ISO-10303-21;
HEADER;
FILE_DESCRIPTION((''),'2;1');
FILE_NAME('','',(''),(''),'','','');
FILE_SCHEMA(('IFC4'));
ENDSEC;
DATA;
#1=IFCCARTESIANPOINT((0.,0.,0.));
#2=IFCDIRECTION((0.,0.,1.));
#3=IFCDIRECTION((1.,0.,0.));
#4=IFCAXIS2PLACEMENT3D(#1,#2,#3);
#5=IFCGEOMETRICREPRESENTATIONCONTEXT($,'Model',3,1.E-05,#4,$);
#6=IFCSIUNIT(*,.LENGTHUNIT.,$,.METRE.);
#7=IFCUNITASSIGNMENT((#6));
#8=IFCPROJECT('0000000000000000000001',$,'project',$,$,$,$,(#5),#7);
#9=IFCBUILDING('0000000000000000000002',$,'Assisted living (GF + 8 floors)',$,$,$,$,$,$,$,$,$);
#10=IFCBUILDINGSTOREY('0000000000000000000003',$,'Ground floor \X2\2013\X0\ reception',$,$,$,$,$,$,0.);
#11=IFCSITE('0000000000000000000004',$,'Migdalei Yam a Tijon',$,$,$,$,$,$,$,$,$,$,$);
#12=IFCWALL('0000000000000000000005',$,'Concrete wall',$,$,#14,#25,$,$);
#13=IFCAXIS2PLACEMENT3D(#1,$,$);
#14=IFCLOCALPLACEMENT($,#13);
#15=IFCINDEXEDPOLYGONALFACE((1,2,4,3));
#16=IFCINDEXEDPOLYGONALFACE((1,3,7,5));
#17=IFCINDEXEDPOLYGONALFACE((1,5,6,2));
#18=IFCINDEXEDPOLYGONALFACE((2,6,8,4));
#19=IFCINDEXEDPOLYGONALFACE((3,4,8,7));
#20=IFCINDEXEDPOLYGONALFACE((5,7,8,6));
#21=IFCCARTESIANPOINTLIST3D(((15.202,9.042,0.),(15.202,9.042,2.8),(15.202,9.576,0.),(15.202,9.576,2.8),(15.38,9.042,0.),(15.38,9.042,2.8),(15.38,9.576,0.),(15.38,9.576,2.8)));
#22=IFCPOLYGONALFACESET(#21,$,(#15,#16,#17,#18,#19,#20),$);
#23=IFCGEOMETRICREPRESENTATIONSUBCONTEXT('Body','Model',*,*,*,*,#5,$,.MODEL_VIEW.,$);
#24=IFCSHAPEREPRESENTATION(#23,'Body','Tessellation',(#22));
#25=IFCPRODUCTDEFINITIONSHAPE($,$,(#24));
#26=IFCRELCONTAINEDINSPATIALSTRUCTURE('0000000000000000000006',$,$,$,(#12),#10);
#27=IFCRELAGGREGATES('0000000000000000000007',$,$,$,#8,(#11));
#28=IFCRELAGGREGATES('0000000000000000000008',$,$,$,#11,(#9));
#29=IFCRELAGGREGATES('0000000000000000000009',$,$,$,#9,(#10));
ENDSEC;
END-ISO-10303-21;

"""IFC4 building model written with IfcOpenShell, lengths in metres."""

from ifc_helpers import new_model, si_unit, frame, origin_with_axes, context, subcontext, project, spatial, line, indexed_curve, outline, extrude, element, save


model = new_model("IFC4")

# Units and contexts
model_context = context("Model", 3, precision=1e-05, world=origin_with_axes())
body_context = subcontext(model_context, "Body", "Model", "MODEL_VIEW")
ifc_project = project(units=[si_unit("LENGTHUNIT", "METRE")], contexts=[model_context])

# Site, building, storey
site = spatial("IfcSite", under=ifc_project, Name="Migdalei Yam a Tijon")
building = spatial("IfcBuilding", under=site, Name="Assisted living (GF + 8 floors)")
storey = spatial("IfcBuildingStorey", under=building, Name="Ground floor – reception", Elevation=0.0)

# Wall
element("IfcWall", 1, inside=storey, Name="Concrete wall", context=body_context, shape_type="SweptSolid", body=[
    extrude(outline(indexed_curve([(0.0, 0.0), (0.178, 0.0), (0.178, 0.534), (0.0, 0.534)], segments=[line(1, 2, 3, 4, 1)])), frame((15.202, 9.042, 0.0), z_axis=(0.0, 0.0, 1.0), x_axis=(1.0, 0.0, 0.0)), (0.0, 0.0, 1.0), 2.8),
])

save(model, "model.ifc")
